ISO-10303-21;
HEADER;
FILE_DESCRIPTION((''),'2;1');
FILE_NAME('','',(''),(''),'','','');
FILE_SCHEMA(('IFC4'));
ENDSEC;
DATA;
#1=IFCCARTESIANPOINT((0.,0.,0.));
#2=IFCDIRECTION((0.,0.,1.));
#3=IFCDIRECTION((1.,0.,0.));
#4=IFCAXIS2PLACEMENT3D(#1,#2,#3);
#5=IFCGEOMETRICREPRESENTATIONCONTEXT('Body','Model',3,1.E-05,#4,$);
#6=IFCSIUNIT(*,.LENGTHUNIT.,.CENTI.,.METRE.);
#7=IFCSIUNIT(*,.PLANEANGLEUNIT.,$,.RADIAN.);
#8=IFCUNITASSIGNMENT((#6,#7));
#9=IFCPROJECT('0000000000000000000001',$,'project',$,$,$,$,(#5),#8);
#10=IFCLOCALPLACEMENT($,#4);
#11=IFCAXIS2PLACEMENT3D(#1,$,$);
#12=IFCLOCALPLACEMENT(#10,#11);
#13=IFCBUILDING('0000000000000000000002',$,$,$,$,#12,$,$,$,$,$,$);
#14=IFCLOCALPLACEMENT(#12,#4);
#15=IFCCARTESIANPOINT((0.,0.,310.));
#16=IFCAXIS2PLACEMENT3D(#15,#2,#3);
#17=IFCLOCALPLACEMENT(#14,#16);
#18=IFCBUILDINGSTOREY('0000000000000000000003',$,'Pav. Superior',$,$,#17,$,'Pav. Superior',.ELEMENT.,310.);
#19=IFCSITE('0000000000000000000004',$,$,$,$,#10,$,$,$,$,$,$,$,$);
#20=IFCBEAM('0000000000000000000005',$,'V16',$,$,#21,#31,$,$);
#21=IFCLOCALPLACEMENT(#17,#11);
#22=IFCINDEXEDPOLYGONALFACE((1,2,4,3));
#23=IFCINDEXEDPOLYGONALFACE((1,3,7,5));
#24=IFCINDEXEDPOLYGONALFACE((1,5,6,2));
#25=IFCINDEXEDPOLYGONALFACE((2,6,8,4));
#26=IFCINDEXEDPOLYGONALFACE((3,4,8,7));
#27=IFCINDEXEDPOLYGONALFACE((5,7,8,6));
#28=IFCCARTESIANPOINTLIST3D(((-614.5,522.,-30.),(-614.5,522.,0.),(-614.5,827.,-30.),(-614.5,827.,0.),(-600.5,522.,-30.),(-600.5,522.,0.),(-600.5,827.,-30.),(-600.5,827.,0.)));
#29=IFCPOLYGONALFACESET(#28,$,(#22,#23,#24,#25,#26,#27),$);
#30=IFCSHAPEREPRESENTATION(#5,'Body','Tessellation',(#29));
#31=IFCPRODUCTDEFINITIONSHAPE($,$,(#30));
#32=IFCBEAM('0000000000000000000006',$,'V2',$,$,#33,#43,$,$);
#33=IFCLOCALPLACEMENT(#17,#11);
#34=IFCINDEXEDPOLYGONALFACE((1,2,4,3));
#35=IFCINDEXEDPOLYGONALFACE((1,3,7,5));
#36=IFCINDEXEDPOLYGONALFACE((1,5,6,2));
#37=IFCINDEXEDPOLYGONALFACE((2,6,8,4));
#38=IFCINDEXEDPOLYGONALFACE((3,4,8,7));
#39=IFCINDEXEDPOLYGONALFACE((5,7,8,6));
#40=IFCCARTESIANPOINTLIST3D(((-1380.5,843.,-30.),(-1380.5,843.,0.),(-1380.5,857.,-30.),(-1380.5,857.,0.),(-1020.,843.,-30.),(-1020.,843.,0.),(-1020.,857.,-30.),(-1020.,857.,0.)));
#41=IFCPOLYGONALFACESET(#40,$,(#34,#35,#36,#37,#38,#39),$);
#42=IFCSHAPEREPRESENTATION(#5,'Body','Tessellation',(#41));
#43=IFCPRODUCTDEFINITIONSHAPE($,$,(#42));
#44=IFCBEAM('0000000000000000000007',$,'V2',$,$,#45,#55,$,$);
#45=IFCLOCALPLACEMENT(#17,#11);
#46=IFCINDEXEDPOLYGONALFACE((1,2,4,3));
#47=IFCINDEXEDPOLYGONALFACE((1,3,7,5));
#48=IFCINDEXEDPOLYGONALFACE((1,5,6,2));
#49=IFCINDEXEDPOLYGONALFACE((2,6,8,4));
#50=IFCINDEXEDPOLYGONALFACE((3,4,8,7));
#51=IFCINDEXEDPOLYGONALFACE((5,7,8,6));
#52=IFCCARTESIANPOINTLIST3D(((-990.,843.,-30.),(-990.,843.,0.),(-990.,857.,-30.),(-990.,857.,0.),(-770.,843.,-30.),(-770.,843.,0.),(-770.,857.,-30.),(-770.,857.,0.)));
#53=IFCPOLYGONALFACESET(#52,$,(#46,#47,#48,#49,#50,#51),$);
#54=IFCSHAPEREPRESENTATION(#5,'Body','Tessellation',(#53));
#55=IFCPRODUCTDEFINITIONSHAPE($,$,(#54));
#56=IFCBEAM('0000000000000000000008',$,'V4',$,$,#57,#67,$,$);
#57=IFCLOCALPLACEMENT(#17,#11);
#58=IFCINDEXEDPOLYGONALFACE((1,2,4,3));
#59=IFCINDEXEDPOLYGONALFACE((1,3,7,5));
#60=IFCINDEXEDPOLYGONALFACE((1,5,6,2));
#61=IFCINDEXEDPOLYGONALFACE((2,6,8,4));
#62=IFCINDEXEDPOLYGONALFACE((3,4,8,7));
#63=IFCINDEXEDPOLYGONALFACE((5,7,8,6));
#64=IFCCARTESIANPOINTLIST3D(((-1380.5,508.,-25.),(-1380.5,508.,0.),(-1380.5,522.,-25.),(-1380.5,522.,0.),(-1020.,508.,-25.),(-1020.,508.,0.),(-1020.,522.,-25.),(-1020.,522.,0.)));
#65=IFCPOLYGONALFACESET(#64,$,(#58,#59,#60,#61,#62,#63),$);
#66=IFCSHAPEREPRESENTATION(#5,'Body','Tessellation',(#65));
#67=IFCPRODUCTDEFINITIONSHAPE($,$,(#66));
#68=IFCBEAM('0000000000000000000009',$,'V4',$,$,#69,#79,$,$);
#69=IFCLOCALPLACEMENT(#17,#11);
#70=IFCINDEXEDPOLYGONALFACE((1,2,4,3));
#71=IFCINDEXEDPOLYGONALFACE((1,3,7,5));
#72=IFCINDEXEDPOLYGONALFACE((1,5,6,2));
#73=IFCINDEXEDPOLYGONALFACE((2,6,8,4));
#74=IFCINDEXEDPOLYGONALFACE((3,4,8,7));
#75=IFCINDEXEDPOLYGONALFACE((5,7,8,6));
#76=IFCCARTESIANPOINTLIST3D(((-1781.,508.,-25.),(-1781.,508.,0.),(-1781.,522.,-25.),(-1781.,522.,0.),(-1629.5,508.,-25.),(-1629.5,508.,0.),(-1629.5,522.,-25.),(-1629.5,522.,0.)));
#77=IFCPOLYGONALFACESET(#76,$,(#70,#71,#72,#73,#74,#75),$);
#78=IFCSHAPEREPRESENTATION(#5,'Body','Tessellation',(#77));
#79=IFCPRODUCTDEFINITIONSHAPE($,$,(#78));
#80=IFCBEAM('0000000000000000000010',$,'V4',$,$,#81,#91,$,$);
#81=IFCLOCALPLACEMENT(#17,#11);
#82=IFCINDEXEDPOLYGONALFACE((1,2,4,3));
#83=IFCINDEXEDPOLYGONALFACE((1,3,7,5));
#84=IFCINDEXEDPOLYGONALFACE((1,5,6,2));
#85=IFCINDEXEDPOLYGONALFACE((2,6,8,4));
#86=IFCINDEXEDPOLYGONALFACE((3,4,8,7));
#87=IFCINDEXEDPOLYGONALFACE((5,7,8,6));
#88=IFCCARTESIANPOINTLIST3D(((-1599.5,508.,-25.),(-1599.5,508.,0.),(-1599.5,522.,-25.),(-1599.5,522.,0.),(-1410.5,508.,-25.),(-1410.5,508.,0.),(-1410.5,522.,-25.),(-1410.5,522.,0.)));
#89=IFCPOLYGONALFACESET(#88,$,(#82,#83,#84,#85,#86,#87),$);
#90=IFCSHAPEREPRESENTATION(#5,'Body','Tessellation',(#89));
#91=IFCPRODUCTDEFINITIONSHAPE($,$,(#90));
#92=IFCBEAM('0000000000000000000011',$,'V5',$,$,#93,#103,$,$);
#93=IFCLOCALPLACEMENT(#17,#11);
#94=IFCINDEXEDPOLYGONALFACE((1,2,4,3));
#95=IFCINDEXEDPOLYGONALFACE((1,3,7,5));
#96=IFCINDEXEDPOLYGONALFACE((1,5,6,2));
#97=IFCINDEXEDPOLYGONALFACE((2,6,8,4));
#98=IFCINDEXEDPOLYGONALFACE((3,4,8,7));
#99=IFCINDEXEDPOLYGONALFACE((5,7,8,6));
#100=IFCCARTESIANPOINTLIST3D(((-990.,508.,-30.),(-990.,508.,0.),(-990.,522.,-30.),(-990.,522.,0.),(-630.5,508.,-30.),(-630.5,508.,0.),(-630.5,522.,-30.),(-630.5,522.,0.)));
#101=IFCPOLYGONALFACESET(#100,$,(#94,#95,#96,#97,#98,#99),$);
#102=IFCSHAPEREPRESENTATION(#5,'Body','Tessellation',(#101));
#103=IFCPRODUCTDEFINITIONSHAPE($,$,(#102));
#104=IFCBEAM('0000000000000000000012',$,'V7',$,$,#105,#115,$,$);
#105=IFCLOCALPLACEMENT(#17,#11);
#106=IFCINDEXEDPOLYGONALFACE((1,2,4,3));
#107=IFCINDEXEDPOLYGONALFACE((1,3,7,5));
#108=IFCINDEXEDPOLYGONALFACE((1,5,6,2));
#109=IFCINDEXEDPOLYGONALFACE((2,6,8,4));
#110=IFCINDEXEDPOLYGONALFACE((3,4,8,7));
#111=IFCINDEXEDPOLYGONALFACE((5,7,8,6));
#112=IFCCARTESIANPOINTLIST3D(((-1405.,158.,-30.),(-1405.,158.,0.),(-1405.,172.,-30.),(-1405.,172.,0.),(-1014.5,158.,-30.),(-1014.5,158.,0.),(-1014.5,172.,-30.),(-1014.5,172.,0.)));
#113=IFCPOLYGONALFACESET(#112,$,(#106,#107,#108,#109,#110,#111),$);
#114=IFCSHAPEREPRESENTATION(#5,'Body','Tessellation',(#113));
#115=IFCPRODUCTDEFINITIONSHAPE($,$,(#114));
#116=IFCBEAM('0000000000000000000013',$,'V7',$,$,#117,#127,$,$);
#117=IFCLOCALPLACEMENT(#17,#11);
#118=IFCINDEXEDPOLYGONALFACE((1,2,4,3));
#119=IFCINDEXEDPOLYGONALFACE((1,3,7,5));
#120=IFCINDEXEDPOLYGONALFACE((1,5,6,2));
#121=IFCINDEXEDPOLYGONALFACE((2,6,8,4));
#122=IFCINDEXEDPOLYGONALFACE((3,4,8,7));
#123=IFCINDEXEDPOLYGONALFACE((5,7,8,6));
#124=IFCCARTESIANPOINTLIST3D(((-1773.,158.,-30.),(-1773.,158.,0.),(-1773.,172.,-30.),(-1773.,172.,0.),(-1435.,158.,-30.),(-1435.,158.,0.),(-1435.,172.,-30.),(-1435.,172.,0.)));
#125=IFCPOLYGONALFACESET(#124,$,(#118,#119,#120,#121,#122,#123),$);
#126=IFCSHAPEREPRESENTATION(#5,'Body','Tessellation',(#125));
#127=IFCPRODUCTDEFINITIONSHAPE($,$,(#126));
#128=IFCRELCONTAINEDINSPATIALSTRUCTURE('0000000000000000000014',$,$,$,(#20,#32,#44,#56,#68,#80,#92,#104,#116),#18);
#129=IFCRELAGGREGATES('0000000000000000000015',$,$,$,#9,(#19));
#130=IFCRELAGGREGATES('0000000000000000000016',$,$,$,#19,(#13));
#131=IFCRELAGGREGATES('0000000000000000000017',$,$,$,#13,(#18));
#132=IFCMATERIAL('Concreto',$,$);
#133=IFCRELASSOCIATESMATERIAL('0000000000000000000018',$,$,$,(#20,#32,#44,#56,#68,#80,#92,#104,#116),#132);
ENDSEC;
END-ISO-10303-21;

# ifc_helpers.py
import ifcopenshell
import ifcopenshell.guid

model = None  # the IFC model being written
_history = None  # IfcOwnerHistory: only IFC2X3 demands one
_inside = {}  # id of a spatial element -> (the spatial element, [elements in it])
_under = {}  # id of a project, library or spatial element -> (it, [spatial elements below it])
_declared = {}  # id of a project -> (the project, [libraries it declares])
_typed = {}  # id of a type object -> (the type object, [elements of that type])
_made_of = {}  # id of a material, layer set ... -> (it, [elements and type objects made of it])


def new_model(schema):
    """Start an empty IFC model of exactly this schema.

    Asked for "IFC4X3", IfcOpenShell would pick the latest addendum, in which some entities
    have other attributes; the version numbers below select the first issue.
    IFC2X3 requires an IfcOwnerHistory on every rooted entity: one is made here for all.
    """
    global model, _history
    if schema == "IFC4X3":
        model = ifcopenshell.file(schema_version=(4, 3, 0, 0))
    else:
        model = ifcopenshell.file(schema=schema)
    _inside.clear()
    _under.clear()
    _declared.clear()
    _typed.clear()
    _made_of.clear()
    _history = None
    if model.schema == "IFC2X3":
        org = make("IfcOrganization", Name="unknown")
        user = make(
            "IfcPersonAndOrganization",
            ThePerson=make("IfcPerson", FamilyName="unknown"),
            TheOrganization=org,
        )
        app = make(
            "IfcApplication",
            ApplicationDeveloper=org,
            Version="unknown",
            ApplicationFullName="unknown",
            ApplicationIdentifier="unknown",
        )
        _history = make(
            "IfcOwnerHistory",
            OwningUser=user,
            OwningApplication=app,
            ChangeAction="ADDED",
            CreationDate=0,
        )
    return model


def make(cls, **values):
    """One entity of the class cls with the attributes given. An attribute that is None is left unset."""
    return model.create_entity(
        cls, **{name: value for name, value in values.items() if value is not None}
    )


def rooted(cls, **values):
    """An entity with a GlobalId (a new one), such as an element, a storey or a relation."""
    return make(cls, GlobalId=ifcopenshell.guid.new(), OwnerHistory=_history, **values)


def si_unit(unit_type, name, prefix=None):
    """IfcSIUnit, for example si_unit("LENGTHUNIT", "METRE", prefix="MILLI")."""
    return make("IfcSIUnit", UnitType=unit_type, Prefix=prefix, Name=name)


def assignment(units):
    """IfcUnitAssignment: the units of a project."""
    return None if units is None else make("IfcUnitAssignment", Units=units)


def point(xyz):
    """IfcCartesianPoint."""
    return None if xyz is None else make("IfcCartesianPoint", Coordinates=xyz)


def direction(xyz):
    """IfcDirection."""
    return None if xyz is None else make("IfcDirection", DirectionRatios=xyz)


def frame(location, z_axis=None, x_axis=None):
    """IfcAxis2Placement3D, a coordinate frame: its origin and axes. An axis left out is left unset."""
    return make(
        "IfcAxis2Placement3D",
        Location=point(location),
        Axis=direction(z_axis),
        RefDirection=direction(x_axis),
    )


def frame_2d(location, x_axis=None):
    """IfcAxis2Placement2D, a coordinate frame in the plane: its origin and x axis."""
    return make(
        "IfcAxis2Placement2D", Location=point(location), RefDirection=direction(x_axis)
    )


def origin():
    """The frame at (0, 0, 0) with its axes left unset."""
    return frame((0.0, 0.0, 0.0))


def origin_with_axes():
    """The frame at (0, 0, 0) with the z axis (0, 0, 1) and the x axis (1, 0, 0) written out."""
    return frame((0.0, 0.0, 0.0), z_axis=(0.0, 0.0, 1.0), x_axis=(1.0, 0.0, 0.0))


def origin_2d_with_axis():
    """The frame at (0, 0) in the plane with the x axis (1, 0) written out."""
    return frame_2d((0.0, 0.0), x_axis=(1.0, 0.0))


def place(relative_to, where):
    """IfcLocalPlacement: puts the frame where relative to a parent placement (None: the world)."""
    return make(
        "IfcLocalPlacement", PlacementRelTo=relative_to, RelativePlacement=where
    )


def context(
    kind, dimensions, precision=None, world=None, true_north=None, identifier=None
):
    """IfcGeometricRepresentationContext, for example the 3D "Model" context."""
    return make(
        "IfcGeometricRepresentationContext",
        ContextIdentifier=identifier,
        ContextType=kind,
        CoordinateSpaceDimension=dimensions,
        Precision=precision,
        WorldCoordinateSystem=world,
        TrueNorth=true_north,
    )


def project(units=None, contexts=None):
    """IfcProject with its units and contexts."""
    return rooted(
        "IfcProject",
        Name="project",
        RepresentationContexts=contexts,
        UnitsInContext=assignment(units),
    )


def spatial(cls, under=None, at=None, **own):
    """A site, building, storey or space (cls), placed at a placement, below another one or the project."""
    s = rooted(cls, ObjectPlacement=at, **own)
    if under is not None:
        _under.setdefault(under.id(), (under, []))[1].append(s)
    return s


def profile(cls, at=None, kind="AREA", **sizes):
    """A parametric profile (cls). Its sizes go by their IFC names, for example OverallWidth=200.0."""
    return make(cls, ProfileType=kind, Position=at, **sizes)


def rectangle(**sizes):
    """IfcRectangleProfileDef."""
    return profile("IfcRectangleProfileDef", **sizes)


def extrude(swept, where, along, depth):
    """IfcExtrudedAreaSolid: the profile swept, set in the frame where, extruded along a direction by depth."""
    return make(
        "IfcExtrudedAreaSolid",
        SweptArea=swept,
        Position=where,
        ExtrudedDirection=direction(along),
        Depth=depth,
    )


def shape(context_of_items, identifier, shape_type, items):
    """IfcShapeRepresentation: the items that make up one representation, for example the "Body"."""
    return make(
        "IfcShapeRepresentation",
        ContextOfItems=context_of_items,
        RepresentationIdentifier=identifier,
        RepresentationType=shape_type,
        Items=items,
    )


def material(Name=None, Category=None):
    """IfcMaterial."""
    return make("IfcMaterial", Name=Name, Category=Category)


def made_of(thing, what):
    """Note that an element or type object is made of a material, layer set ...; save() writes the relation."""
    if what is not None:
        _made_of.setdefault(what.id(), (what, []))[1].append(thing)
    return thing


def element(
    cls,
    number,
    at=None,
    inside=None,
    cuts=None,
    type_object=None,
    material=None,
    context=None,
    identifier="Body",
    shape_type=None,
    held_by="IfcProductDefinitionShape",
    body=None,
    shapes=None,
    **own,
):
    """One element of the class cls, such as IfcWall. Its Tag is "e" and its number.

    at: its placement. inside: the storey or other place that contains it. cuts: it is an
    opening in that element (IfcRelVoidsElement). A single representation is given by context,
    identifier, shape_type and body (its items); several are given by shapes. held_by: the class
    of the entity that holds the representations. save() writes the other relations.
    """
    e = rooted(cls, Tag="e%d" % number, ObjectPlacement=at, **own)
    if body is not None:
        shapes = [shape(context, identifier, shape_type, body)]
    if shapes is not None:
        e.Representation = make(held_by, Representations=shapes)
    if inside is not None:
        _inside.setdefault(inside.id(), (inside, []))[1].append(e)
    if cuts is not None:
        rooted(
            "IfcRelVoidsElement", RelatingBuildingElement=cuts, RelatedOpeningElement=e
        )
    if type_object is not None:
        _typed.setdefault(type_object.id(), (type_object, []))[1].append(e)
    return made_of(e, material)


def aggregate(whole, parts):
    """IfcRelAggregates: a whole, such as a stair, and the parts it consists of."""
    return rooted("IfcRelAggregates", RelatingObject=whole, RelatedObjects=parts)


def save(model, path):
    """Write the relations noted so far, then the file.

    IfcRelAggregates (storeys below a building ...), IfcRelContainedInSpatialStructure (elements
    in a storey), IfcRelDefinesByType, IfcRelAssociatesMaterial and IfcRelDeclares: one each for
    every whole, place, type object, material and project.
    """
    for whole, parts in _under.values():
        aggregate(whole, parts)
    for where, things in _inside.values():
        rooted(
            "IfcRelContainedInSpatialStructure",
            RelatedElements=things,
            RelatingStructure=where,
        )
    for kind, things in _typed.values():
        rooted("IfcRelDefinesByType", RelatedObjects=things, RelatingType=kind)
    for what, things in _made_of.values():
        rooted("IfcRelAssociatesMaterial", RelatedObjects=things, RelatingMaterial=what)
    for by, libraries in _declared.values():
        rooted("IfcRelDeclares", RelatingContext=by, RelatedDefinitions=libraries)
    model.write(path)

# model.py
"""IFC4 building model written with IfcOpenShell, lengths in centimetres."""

from ifc_helpers import new_model, si_unit, frame, origin, origin_with_axes, origin_2d_with_axis, place, context, project, spatial, rectangle, extrude, material, element, save


model = new_model("IFC4")

# Units and contexts
model_context = context("Model", 3, precision=1e-05, world=origin_with_axes(), identifier="Body")
ifc_project = project(units=[si_unit("LENGTHUNIT", "METRE", prefix="CENTI"), si_unit("PLANEANGLEUNIT", "RADIAN")], contexts=[model_context])

# Site, building, storey
site_placement = place(None, origin_with_axes())
site = spatial("IfcSite", under=ifc_project, at=site_placement)
building_placement = place(site_placement, origin())
building = spatial("IfcBuilding", under=site, at=building_placement)
placement = place(building_placement, origin_with_axes())
storey_placement = place(placement, frame((0.0, 0.0, 310.0), z_axis=(0.0, 0.0, 1.0), x_axis=(1.0, 0.0, 0.0)))
storey = spatial("IfcBuildingStorey", under=building, at=storey_placement, Name="Pav. Superior", LongName="Pav. Superior", CompositionType="ELEMENT", Elevation=310.0)

# Shared definitions
ifc_material = material(Name="Concreto")

# Beams
beam_1_placement = place(storey_placement, frame((-607.5, 674.5, 0.0), z_axis=(0.0, 0.0, 1.0), x_axis=(1.0, 0.0, 0.0)))
element("IfcBeam", 1, at=beam_1_placement, inside=storey, material=ifc_material, Name="V16", context=model_context, shape_type="SolidModel", body=[
    extrude(rectangle(XDim=14.0, YDim=30.0, at=origin_2d_with_axis()), frame((0.0, -152.5, -15.0), z_axis=(0.0, 1.0, 0.0), x_axis=(-1.0, 0.0, 0.0)), (0.0, 0.0, 1.0), 305.0),
])
beam_2_placement = place(storey_placement, frame((-1200.25, 850.0, 0.0), z_axis=(0.0, 0.0, 1.0), x_axis=(1.0, 0.0, 0.0)))
element("IfcBeam", 2, at=beam_2_placement, inside=storey, material=ifc_material, Name="V2", context=model_context, shape_type="SolidModel", body=[
    extrude(rectangle(XDim=14.0, YDim=30.0, at=origin_2d_with_axis()), frame((-180.25, 0.0, -15.0), z_axis=(1.0, 0.0, 0.0), x_axis=(0.0, -1.0, 0.0)), (0.0, 0.0, 1.0), 360.5),
])
beam_3_placement = place(storey_placement, frame((-880.0, 850.0, 0.0), z_axis=(0.0, 0.0, 1.0), x_axis=(1.0, 0.0, 0.0)))
element("IfcBeam", 3, at=beam_3_placement, inside=storey, material=ifc_material, Name="V2", context=model_context, shape_type="SolidModel", body=[
    extrude(rectangle(XDim=14.0, YDim=30.0, at=origin_2d_with_axis()), frame((-110.0, 0.0, -15.0), z_axis=(1.0, 0.0, 0.0), x_axis=(0.0, 1.0, 0.0)), (0.0, 0.0, 1.0), 220.0),
])
beam_4_placement = place(storey_placement, frame((-1200.25, 515.0, 0.0), z_axis=(0.0, 0.0, 1.0), x_axis=(1.0, 0.0, 0.0)))
element("IfcBeam", 4, at=beam_4_placement, inside=storey, material=ifc_material, Name="V4", context=model_context, shape_type="SolidModel", body=[
    extrude(rectangle(XDim=14.0, YDim=25.0, at=origin_2d_with_axis()), frame((-180.25, 0.0, -12.5), z_axis=(1.0, 0.0, 0.0), x_axis=(0.0, -1.0, 0.0)), (0.0, 0.0, 1.0), 360.5),
])
beam_5_placement = place(storey_placement, frame((-1705.25, 515.0, 0.0), z_axis=(0.0, 0.0, 1.0), x_axis=(1.0, 0.0, 0.0)))
element("IfcBeam", 5, at=beam_5_placement, inside=storey, material=ifc_material, Name="V4", context=model_context, shape_type="SolidModel", body=[
    extrude(rectangle(XDim=14.0, YDim=25.0, at=origin_2d_with_axis()), frame((-75.75, 0.0, -12.5), z_axis=(1.0, 0.0, 0.0), x_axis=(0.0, -1.0, 0.0)), (0.0, 0.0, 1.0), 151.5),
])
beam_6_placement = place(storey_placement, frame((-1505.0, 515.0, 0.0), z_axis=(0.0, 0.0, 1.0), x_axis=(1.0, 0.0, 0.0)))
element("IfcBeam", 6, at=beam_6_placement, inside=storey, material=ifc_material, Name="V4", context=model_context, shape_type="SolidModel", body=[
    extrude(rectangle(XDim=14.0, YDim=25.0, at=origin_2d_with_axis()), frame((-94.5, 0.0, -12.5), z_axis=(1.0, 0.0, 0.0), x_axis=(0.0, -1.0, 0.0)), (0.0, 0.0, 1.0), 189.0),
])
beam_7_placement = place(storey_placement, frame((-810.25, 515.0, 0.0), z_axis=(0.0, 0.0, 1.0), x_axis=(1.0, 0.0, 0.0)))
element("IfcBeam", 7, at=beam_7_placement, inside=storey, material=ifc_material, Name="V5", context=model_context, shape_type="SolidModel", body=[
    extrude(rectangle(XDim=14.0, YDim=30.0, at=origin_2d_with_axis()), frame((-179.75, 0.0, -15.0), z_axis=(1.0, 0.0, 0.0), x_axis=(0.0, -1.0, 0.0)), (0.0, 0.0, 1.0), 359.5),
])
beam_8_placement = place(storey_placement, frame((-1209.75, 165.0, 0.0), z_axis=(0.0, 0.0, 1.0), x_axis=(1.0, 0.0, 0.0)))
element("IfcBeam", 8, at=beam_8_placement, inside=storey, material=ifc_material, Name="V7", context=model_context, shape_type="SolidModel", body=[
    extrude(rectangle(XDim=14.0, YDim=30.0, at=origin_2d_with_axis()), frame((-195.25, 0.0, -15.0), z_axis=(1.0, 0.0, 0.0), x_axis=(0.0, -1.0, 0.0)), (0.0, 0.0, 1.0), 390.5),
])
beam_9_placement = place(storey_placement, frame((-1604.0, 165.0, 0.0), z_axis=(0.0, 0.0, 1.0), x_axis=(1.0, 0.0, 0.0)))
element("IfcBeam", 9, at=beam_9_placement, inside=storey, material=ifc_material, Name="V7", context=model_context, shape_type="SolidModel", body=[
    extrude(rectangle(XDim=14.0, YDim=30.0, at=origin_2d_with_axis()), frame((-169.0, 0.0, -15.0), z_axis=(1.0, 0.0, 0.0), x_axis=(0.0, -1.0, 0.0)), (0.0, 0.0, 1.0), 338.0),
])

save(model, "model.ifc")
